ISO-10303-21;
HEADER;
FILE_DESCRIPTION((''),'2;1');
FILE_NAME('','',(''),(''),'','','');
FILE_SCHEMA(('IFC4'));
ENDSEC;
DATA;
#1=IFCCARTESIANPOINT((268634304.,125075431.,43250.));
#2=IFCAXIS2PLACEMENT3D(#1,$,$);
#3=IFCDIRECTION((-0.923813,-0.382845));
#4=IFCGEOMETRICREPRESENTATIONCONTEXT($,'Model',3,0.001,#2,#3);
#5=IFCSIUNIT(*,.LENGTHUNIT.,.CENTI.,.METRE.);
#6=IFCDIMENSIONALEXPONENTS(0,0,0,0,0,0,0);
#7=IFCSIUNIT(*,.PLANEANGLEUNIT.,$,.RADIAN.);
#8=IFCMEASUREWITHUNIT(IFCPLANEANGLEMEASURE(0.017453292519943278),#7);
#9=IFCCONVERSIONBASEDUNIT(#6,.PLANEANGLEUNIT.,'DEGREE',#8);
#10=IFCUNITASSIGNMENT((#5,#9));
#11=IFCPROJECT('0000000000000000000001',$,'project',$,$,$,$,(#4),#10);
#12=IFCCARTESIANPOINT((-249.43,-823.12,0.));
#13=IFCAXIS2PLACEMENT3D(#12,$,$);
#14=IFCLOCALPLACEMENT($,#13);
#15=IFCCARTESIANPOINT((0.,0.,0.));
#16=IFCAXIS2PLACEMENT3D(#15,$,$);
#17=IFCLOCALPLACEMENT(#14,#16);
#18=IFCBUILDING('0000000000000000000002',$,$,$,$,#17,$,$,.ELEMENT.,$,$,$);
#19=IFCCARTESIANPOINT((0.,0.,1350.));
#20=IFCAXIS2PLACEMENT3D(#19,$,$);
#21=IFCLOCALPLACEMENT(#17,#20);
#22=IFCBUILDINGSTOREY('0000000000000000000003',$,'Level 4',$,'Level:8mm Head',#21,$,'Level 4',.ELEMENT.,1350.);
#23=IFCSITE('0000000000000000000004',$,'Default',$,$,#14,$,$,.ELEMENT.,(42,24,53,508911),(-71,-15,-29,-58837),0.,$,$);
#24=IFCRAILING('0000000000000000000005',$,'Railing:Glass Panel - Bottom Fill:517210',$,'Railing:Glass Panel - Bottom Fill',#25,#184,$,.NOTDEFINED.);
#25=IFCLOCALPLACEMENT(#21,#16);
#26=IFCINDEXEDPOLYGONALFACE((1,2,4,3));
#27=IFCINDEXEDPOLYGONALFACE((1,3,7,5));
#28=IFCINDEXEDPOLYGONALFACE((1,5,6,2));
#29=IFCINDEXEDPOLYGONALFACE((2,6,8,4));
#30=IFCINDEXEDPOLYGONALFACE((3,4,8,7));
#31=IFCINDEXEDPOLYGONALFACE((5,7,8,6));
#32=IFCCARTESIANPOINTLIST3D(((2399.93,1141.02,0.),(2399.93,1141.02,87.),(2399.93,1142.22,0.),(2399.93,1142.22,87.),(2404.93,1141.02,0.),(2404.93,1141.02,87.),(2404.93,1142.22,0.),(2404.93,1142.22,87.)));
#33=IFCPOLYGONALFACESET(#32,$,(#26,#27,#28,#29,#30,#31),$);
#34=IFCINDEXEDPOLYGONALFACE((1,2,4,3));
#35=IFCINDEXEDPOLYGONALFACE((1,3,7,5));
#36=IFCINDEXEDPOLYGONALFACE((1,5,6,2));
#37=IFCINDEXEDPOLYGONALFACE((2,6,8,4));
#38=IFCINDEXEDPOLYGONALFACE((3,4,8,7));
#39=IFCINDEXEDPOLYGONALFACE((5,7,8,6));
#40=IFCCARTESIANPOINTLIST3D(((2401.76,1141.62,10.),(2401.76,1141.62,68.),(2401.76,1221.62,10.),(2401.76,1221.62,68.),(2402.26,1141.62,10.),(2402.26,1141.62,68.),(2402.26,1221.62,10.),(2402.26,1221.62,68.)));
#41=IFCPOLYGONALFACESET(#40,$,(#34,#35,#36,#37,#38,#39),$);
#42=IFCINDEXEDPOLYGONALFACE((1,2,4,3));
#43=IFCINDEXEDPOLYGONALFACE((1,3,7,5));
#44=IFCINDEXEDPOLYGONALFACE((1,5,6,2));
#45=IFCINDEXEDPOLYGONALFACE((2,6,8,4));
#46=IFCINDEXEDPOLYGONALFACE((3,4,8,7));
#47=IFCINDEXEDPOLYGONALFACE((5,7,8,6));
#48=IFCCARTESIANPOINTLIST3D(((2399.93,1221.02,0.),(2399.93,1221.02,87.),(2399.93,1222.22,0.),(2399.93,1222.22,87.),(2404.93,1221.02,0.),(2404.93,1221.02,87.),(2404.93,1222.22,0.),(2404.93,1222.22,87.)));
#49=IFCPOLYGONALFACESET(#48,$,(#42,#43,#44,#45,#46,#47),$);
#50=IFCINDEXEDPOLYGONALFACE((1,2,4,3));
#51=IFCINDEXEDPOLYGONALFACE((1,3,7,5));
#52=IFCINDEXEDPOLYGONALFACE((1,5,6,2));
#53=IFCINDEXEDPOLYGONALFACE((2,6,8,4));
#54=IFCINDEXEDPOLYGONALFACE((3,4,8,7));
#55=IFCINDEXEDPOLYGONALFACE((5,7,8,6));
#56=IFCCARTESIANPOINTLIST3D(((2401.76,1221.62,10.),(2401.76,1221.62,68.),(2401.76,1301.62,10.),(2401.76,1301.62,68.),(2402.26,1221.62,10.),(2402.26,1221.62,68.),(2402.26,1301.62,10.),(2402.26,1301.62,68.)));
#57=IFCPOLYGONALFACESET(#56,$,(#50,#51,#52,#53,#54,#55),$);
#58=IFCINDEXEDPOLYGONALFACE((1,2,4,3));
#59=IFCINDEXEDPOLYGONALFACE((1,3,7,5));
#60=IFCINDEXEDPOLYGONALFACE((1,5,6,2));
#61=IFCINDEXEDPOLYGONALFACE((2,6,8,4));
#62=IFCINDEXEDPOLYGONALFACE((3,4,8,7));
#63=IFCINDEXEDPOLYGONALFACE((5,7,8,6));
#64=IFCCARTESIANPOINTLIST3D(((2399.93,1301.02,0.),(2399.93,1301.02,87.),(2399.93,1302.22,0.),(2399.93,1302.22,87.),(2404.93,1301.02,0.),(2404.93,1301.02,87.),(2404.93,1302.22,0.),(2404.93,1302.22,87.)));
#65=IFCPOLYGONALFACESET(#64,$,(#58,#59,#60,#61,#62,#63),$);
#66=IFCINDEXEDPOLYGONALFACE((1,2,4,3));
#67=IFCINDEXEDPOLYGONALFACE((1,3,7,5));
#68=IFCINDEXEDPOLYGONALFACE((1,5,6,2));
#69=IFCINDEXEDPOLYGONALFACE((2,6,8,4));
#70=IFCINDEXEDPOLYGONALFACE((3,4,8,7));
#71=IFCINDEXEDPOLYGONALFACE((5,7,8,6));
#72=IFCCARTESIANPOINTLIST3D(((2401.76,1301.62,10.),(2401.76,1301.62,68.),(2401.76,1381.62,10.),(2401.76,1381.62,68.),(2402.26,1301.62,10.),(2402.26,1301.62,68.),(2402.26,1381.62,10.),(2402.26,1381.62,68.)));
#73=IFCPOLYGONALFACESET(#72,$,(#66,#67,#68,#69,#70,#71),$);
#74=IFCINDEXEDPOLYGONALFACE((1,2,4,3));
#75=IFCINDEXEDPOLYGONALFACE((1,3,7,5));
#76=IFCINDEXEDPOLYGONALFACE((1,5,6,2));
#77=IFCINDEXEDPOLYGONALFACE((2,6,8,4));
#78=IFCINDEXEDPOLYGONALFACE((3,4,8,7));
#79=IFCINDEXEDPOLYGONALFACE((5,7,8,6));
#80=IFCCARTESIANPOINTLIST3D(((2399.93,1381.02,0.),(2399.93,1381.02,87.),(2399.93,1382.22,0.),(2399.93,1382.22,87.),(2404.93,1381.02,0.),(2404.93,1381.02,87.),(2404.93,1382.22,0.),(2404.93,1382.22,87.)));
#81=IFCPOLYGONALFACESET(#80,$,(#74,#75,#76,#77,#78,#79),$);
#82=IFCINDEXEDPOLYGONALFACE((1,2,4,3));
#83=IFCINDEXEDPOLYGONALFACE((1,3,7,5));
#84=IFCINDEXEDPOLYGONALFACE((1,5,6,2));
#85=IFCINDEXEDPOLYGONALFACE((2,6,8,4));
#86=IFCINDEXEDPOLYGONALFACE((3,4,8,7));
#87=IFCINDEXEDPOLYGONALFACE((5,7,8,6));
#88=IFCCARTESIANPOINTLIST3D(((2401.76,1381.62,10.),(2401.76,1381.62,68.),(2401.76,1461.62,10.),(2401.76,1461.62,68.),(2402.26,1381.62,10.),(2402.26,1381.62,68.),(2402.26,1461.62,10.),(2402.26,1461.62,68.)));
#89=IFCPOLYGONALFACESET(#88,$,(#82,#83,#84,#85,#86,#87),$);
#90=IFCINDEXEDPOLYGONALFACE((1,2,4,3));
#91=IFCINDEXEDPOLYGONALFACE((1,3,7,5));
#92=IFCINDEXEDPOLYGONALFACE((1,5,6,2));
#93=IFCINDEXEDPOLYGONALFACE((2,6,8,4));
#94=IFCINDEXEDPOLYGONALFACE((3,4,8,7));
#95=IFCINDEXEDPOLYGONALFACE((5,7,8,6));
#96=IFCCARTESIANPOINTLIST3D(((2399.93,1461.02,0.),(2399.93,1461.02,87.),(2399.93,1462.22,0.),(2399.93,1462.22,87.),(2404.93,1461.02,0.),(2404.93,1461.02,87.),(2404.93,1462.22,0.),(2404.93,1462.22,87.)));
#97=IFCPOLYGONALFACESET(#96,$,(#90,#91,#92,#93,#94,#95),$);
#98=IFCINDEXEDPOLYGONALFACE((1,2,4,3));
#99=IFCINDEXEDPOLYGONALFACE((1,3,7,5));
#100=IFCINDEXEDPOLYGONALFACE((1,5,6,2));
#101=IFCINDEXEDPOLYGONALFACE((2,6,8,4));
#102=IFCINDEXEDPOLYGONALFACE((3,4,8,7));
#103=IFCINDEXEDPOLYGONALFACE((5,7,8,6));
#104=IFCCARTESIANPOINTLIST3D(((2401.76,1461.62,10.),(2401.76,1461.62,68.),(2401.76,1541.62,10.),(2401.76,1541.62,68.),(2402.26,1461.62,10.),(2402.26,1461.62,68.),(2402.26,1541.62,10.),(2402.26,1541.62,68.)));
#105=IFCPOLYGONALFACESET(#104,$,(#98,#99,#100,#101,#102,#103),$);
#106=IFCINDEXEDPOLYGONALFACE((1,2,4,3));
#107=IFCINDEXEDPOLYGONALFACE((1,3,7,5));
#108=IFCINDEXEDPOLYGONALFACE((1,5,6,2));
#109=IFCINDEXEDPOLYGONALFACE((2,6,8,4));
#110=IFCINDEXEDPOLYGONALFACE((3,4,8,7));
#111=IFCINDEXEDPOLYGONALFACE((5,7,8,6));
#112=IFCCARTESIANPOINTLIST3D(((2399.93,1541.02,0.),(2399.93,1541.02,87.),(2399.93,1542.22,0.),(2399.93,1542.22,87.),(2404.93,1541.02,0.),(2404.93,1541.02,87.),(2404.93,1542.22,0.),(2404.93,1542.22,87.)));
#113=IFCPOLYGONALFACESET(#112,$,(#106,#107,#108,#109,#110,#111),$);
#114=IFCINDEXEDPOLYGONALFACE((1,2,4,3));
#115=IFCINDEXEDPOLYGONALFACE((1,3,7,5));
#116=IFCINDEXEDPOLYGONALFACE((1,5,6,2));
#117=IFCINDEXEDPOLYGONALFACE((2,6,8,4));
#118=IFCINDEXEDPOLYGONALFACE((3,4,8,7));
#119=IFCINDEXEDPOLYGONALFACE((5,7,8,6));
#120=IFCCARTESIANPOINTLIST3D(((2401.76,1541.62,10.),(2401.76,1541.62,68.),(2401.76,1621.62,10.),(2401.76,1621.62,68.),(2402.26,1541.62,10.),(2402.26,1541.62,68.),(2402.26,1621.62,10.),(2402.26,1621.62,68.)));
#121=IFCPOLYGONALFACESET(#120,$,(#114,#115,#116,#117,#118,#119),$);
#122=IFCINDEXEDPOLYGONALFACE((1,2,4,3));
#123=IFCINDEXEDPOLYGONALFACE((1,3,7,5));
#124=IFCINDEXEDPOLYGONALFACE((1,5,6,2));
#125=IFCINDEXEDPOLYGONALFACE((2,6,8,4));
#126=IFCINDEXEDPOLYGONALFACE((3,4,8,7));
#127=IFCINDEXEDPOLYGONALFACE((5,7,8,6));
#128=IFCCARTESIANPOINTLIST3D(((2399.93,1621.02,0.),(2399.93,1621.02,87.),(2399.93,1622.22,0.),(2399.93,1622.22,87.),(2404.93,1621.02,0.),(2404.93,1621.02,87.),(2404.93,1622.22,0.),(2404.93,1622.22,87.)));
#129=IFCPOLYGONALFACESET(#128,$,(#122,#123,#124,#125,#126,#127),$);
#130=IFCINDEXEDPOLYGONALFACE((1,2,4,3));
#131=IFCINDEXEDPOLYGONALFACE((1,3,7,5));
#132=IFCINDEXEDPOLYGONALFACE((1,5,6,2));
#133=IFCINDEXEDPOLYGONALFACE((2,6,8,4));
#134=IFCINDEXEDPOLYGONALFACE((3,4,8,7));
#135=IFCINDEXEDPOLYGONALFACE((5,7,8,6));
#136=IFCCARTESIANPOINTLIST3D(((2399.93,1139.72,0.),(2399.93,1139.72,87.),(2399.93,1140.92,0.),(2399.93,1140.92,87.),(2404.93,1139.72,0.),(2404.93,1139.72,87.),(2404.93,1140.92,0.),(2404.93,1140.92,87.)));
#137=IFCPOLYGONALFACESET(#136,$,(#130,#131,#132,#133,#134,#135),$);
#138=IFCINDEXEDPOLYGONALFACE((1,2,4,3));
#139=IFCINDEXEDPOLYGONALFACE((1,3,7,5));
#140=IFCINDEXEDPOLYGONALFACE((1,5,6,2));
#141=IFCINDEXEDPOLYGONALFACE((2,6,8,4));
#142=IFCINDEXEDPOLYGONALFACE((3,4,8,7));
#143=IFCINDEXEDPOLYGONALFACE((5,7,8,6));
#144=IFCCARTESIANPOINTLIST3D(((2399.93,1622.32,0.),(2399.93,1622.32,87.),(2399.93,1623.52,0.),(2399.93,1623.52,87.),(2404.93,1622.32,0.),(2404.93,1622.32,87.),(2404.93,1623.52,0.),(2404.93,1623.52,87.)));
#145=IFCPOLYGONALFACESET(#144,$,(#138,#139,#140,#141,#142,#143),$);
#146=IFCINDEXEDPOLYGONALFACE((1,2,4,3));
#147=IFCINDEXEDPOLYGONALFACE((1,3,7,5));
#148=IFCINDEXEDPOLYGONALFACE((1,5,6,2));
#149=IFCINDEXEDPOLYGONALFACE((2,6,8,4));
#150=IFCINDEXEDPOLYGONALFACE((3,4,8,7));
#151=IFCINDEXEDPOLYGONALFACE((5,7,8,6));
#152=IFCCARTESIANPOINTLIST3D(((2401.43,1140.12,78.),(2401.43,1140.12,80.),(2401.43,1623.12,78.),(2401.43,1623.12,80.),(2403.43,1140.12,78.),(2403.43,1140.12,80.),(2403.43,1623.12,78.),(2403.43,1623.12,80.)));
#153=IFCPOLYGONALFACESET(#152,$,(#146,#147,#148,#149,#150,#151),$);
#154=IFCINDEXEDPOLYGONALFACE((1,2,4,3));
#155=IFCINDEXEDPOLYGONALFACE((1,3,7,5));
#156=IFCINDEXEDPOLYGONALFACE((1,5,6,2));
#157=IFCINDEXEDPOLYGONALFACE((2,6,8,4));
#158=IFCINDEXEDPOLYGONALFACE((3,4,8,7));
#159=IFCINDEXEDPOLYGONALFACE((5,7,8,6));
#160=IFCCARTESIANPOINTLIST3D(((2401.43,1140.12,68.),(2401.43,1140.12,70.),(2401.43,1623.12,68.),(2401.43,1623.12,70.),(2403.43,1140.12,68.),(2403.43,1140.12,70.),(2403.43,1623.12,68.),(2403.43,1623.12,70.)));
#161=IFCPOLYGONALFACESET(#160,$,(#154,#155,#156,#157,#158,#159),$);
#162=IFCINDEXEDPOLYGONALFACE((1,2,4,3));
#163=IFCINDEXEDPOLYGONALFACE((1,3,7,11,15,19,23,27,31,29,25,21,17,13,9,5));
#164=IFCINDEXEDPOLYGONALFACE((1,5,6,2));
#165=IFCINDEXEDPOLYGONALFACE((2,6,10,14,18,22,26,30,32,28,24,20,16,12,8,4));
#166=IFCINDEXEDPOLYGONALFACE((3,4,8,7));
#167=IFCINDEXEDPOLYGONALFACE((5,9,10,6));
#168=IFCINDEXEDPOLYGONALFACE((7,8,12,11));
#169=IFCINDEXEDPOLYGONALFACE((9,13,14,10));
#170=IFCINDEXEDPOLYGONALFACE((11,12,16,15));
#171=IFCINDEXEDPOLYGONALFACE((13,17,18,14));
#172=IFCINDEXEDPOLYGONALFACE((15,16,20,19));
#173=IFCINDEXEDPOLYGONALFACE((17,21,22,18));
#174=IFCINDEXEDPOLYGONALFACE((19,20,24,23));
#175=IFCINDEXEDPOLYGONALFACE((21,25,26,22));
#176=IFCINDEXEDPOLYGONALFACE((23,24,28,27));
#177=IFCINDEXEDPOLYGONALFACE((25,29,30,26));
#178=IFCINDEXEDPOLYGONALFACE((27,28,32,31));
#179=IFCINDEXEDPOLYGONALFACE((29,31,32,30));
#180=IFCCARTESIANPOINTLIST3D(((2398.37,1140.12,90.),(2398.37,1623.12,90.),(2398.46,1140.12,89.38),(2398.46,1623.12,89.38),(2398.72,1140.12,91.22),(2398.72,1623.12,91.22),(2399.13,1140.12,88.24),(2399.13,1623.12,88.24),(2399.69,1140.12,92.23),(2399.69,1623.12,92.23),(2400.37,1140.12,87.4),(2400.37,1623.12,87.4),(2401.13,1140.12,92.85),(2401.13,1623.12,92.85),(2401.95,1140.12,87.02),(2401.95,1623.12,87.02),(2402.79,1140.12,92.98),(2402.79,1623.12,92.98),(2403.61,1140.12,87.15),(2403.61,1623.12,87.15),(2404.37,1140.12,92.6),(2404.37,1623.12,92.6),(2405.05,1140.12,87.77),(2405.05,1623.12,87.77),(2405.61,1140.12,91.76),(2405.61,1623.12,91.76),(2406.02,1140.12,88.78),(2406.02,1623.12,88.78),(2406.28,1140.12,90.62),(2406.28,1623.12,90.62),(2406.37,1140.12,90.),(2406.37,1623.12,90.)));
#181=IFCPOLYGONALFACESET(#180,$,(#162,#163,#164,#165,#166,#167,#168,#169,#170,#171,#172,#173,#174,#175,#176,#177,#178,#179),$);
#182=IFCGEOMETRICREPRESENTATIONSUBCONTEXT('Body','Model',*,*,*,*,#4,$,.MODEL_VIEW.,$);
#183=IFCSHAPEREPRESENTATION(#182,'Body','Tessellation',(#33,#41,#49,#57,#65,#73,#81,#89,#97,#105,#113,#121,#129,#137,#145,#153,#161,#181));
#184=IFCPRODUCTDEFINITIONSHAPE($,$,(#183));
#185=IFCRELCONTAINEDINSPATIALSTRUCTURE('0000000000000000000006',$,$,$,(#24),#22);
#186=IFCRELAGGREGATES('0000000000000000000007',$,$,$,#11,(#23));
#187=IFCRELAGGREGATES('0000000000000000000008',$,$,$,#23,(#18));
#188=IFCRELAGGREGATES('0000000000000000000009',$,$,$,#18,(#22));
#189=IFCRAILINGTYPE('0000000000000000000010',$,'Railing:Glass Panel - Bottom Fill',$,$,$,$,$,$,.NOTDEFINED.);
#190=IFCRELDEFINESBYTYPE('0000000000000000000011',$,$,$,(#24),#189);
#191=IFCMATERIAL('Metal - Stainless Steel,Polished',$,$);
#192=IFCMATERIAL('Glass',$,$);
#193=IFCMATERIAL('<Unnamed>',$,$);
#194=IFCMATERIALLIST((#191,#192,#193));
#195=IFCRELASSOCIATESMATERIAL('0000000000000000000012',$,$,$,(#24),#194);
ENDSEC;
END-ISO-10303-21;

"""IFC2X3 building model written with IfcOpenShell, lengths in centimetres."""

from ifc_helpers import new_model, entity, si_unit, converted_unit, direction, frame, frame_2d, origin, place, context, subcontext, project, spatial, polyline, rectangle, outline, extrude, material, material_list, type_object, element, save


model = new_model("IFC2X3")

# Units and contexts
model_context = context("Model", 3, precision=0.001, world=frame((268634304.0, 125075431.0, 43250.0)), true_north=direction((-0.923813, -0.382845)))
body_context = subcontext(model_context, "Body", "Model", "MODEL_VIEW")
ifc_project = project(units=[si_unit("LENGTHUNIT", "METRE", prefix="CENTI"), converted_unit("PLANEANGLEUNIT", "DEGREE", entity("IfcPlaneAngleMeasure", 0.017453292519943278), si_unit("PLANEANGLEUNIT", "RADIAN"), dimensions=[0, 0, 0, 0, 0, 0, 0])], contexts=[model_context])

# Site, building, storey
site_placement = place(None, frame((-249.43, -823.12, 0.0)))
site = spatial("IfcSite", under=ifc_project, at=site_placement, Name="Default", CompositionType="ELEMENT", RefLatitude=(42, 24, 53, 508911), RefLongitude=(-71, -15, -29, -58837), RefElevation=0.0)
building_placement = place(site_placement, origin())
building = spatial("IfcBuilding", under=site, at=building_placement, CompositionType="ELEMENT")
storey_placement = place(building_placement, frame((0.0, 0.0, 1350.0)))
storey = spatial("IfcBuildingStorey", under=building, at=storey_placement, Name="Level 4", ObjectType="Level:8mm Head", LongName="Level 4", CompositionType="ELEMENT", Elevation=1350.0)

# Railing
ifc_material_1 = material(Name="Metal - Stainless Steel,Polished")
ifc_material_2 = material(Name="Glass")
ifc_material_3 = material(Name="<Unnamed>")
ifc_material_list_1 = material_list([ifc_material_1, ifc_material_2, ifc_material_3])
railing_type = type_object("IfcRailingType", Name="Railing:Glass Panel - Bottom Fill", PredefinedType="NOTDEFINED")
railing_placement = place(storey_placement, frame((2398.21, 1139.72, 0.0)))
element("IfcRailing", 1, at=railing_placement, inside=storey, type_object=railing_type, material=ifc_material_list_1, Name="Railing:Glass Panel - Bottom Fill:517210", ObjectType="Railing:Glass Panel - Bottom Fill", PredefinedType="NOTDEFINED", context=body_context, shape_type="SweptSolid", body=[
    extrude(rectangle(XDim=5.0, YDim=1.2, at=frame_2d((0.0, 0.0), x_axis=(1.0, 0.0))), frame((4.22, 1.9, 0.0), z_axis=(0.0, 0.0, 1.0), x_axis=(-1.0, 0.0, 0.0)), (0.0, 0.0, 1.0), 87.0),
    extrude(rectangle(XDim=0.5, YDim=80.0, at=frame_2d((0.0, 0.0), x_axis=(1.0, 0.0))), frame((3.8, 41.9, 10.0), z_axis=(0.0, 0.0, 1.0), x_axis=(-1.0, 0.0, 0.0)), (0.0, 0.0, 1.0), 58.0),
    extrude(rectangle(XDim=5.0, YDim=1.2, at=frame_2d((0.0, 0.0), x_axis=(1.0, 0.0))), frame((4.22, 81.9, 0.0), z_axis=(0.0, 0.0, 1.0), x_axis=(-1.0, 0.0, 0.0)), (0.0, 0.0, 1.0), 87.0),
    extrude(rectangle(XDim=0.5, YDim=80.0, at=frame_2d((0.0, 0.0), x_axis=(1.0, 0.0))), frame((3.8, 121.9, 10.0), z_axis=(0.0, 0.0, 1.0), x_axis=(-1.0, 0.0, 0.0)), (0.0, 0.0, 1.0), 58.0),
    extrude(rectangle(XDim=5.0, YDim=1.2, at=frame_2d((0.0, 0.0), x_axis=(1.0, 0.0))), frame((4.22, 161.9, 0.0), z_axis=(0.0, 0.0, 1.0), x_axis=(-1.0, 0.0, 0.0)), (0.0, 0.0, 1.0), 87.0),
    extrude(rectangle(XDim=0.5, YDim=80.0, at=frame_2d((0.0, 0.0), x_axis=(1.0, 0.0))), frame((3.8, 201.9, 10.0), z_axis=(0.0, 0.0, 1.0), x_axis=(-1.0, 0.0, 0.0)), (0.0, 0.0, 1.0), 58.0),
    extrude(rectangle(XDim=5.0, YDim=1.2, at=frame_2d((0.0, 0.0), x_axis=(1.0, 0.0))), frame((4.22, 241.9, 0.0), z_axis=(0.0, 0.0, 1.0), x_axis=(-1.0, 0.0, 0.0)), (0.0, 0.0, 1.0), 87.0),
    extrude(rectangle(XDim=0.5, YDim=80.0, at=frame_2d((0.0, 0.0), x_axis=(1.0, 0.0))), frame((3.8, 281.9, 10.0), z_axis=(0.0, 0.0, 1.0), x_axis=(-1.0, 0.0, 0.0)), (0.0, 0.0, 1.0), 58.0),
    extrude(rectangle(XDim=5.0, YDim=1.2, at=frame_2d((0.0, 0.0), x_axis=(1.0, 0.0))), frame((4.22, 321.9, 0.0), z_axis=(0.0, 0.0, 1.0), x_axis=(-1.0, 0.0, 0.0)), (0.0, 0.0, 1.0), 87.0),
    extrude(rectangle(XDim=0.5, YDim=80.0, at=frame_2d((0.0, 0.0), x_axis=(1.0, 0.0))), frame((3.8, 361.9, 10.0), z_axis=(0.0, 0.0, 1.0), x_axis=(-1.0, 0.0, 0.0)), (0.0, 0.0, 1.0), 58.0),
    extrude(rectangle(XDim=5.0, YDim=1.2, at=frame_2d((0.0, 0.0), x_axis=(1.0, 0.0))), frame((4.22, 401.9, 0.0), z_axis=(0.0, 0.0, 1.0), x_axis=(-1.0, 0.0, 0.0)), (0.0, 0.0, 1.0), 87.0),
    extrude(rectangle(XDim=0.5, YDim=80.0, at=frame_2d((0.0, 0.0), x_axis=(1.0, 0.0))), frame((3.8, 441.9, 10.0), z_axis=(0.0, 0.0, 1.0), x_axis=(-1.0, 0.0, 0.0)), (0.0, 0.0, 1.0), 58.0),
    extrude(rectangle(XDim=5.0, YDim=1.2, at=frame_2d((0.0, 0.0), x_axis=(1.0, 0.0))), frame((4.22, 481.9, 0.0), z_axis=(0.0, 0.0, 1.0), x_axis=(-1.0, 0.0, 0.0)), (0.0, 0.0, 1.0), 87.0),
    extrude(rectangle(XDim=5.0, YDim=1.2, at=frame_2d((0.0, 0.0), x_axis=(1.0, 0.0))), frame((4.22, 0.6, 0.0), z_axis=(0.0, 0.0, 1.0), x_axis=(-1.0, 0.0, 0.0)), (0.0, 0.0, 1.0), 87.0),
    extrude(rectangle(XDim=5.0, YDim=1.2, at=frame_2d((0.0, 0.0), x_axis=(1.0, 0.0))), frame((4.22, 483.2, 0.0), z_axis=(0.0, 0.0, 1.0), x_axis=(-1.0, 0.0, 0.0)), (0.0, 0.0, 1.0), 87.0),
    extrude(rectangle(XDim=483.0, YDim=2.0, at=frame_2d((0.0, 0.0), x_axis=(1.0, 0.0))), frame((4.22, 241.9, 78.0), z_axis=(0.0, 0.0, 1.0), x_axis=(0.0, -1.0, 0.0)), (0.0, 0.0, 1.0), 2.0),
    extrude(rectangle(XDim=483.0, YDim=2.0, at=frame_2d((0.0, 0.0), x_axis=(1.0, 0.0))), frame((4.22, 241.9, 68.0), z_axis=(0.0, 0.0, 1.0), x_axis=(0.0, -1.0, 0.0)), (0.0, 0.0, 1.0), 2.0),
    extrude(outline(polyline([(-1.09, -3.85), (0.18, -3.85), (1.42, -3.18), (2.41, -1.97), (2.98, -0.41), (3.04, 1.22), (2.58, 2.63), (1.67, 3.59), (1.09, 3.85), (-0.18, 3.85), (-1.42, 3.18), (-2.41, 1.97), (-2.98, 0.41), (-3.04, -1.22), (-2.58, -2.63), (-1.67, -3.59), (-1.09, -3.85)])), frame((4.16, 0.4, 90.0), z_axis=(0.0, 1.0, 0.0), x_axis=(-0.27267, 0.0, -0.962108)), (0.0, 0.0, 1.0), 483.0),
])

save(model, "model.ifc")
